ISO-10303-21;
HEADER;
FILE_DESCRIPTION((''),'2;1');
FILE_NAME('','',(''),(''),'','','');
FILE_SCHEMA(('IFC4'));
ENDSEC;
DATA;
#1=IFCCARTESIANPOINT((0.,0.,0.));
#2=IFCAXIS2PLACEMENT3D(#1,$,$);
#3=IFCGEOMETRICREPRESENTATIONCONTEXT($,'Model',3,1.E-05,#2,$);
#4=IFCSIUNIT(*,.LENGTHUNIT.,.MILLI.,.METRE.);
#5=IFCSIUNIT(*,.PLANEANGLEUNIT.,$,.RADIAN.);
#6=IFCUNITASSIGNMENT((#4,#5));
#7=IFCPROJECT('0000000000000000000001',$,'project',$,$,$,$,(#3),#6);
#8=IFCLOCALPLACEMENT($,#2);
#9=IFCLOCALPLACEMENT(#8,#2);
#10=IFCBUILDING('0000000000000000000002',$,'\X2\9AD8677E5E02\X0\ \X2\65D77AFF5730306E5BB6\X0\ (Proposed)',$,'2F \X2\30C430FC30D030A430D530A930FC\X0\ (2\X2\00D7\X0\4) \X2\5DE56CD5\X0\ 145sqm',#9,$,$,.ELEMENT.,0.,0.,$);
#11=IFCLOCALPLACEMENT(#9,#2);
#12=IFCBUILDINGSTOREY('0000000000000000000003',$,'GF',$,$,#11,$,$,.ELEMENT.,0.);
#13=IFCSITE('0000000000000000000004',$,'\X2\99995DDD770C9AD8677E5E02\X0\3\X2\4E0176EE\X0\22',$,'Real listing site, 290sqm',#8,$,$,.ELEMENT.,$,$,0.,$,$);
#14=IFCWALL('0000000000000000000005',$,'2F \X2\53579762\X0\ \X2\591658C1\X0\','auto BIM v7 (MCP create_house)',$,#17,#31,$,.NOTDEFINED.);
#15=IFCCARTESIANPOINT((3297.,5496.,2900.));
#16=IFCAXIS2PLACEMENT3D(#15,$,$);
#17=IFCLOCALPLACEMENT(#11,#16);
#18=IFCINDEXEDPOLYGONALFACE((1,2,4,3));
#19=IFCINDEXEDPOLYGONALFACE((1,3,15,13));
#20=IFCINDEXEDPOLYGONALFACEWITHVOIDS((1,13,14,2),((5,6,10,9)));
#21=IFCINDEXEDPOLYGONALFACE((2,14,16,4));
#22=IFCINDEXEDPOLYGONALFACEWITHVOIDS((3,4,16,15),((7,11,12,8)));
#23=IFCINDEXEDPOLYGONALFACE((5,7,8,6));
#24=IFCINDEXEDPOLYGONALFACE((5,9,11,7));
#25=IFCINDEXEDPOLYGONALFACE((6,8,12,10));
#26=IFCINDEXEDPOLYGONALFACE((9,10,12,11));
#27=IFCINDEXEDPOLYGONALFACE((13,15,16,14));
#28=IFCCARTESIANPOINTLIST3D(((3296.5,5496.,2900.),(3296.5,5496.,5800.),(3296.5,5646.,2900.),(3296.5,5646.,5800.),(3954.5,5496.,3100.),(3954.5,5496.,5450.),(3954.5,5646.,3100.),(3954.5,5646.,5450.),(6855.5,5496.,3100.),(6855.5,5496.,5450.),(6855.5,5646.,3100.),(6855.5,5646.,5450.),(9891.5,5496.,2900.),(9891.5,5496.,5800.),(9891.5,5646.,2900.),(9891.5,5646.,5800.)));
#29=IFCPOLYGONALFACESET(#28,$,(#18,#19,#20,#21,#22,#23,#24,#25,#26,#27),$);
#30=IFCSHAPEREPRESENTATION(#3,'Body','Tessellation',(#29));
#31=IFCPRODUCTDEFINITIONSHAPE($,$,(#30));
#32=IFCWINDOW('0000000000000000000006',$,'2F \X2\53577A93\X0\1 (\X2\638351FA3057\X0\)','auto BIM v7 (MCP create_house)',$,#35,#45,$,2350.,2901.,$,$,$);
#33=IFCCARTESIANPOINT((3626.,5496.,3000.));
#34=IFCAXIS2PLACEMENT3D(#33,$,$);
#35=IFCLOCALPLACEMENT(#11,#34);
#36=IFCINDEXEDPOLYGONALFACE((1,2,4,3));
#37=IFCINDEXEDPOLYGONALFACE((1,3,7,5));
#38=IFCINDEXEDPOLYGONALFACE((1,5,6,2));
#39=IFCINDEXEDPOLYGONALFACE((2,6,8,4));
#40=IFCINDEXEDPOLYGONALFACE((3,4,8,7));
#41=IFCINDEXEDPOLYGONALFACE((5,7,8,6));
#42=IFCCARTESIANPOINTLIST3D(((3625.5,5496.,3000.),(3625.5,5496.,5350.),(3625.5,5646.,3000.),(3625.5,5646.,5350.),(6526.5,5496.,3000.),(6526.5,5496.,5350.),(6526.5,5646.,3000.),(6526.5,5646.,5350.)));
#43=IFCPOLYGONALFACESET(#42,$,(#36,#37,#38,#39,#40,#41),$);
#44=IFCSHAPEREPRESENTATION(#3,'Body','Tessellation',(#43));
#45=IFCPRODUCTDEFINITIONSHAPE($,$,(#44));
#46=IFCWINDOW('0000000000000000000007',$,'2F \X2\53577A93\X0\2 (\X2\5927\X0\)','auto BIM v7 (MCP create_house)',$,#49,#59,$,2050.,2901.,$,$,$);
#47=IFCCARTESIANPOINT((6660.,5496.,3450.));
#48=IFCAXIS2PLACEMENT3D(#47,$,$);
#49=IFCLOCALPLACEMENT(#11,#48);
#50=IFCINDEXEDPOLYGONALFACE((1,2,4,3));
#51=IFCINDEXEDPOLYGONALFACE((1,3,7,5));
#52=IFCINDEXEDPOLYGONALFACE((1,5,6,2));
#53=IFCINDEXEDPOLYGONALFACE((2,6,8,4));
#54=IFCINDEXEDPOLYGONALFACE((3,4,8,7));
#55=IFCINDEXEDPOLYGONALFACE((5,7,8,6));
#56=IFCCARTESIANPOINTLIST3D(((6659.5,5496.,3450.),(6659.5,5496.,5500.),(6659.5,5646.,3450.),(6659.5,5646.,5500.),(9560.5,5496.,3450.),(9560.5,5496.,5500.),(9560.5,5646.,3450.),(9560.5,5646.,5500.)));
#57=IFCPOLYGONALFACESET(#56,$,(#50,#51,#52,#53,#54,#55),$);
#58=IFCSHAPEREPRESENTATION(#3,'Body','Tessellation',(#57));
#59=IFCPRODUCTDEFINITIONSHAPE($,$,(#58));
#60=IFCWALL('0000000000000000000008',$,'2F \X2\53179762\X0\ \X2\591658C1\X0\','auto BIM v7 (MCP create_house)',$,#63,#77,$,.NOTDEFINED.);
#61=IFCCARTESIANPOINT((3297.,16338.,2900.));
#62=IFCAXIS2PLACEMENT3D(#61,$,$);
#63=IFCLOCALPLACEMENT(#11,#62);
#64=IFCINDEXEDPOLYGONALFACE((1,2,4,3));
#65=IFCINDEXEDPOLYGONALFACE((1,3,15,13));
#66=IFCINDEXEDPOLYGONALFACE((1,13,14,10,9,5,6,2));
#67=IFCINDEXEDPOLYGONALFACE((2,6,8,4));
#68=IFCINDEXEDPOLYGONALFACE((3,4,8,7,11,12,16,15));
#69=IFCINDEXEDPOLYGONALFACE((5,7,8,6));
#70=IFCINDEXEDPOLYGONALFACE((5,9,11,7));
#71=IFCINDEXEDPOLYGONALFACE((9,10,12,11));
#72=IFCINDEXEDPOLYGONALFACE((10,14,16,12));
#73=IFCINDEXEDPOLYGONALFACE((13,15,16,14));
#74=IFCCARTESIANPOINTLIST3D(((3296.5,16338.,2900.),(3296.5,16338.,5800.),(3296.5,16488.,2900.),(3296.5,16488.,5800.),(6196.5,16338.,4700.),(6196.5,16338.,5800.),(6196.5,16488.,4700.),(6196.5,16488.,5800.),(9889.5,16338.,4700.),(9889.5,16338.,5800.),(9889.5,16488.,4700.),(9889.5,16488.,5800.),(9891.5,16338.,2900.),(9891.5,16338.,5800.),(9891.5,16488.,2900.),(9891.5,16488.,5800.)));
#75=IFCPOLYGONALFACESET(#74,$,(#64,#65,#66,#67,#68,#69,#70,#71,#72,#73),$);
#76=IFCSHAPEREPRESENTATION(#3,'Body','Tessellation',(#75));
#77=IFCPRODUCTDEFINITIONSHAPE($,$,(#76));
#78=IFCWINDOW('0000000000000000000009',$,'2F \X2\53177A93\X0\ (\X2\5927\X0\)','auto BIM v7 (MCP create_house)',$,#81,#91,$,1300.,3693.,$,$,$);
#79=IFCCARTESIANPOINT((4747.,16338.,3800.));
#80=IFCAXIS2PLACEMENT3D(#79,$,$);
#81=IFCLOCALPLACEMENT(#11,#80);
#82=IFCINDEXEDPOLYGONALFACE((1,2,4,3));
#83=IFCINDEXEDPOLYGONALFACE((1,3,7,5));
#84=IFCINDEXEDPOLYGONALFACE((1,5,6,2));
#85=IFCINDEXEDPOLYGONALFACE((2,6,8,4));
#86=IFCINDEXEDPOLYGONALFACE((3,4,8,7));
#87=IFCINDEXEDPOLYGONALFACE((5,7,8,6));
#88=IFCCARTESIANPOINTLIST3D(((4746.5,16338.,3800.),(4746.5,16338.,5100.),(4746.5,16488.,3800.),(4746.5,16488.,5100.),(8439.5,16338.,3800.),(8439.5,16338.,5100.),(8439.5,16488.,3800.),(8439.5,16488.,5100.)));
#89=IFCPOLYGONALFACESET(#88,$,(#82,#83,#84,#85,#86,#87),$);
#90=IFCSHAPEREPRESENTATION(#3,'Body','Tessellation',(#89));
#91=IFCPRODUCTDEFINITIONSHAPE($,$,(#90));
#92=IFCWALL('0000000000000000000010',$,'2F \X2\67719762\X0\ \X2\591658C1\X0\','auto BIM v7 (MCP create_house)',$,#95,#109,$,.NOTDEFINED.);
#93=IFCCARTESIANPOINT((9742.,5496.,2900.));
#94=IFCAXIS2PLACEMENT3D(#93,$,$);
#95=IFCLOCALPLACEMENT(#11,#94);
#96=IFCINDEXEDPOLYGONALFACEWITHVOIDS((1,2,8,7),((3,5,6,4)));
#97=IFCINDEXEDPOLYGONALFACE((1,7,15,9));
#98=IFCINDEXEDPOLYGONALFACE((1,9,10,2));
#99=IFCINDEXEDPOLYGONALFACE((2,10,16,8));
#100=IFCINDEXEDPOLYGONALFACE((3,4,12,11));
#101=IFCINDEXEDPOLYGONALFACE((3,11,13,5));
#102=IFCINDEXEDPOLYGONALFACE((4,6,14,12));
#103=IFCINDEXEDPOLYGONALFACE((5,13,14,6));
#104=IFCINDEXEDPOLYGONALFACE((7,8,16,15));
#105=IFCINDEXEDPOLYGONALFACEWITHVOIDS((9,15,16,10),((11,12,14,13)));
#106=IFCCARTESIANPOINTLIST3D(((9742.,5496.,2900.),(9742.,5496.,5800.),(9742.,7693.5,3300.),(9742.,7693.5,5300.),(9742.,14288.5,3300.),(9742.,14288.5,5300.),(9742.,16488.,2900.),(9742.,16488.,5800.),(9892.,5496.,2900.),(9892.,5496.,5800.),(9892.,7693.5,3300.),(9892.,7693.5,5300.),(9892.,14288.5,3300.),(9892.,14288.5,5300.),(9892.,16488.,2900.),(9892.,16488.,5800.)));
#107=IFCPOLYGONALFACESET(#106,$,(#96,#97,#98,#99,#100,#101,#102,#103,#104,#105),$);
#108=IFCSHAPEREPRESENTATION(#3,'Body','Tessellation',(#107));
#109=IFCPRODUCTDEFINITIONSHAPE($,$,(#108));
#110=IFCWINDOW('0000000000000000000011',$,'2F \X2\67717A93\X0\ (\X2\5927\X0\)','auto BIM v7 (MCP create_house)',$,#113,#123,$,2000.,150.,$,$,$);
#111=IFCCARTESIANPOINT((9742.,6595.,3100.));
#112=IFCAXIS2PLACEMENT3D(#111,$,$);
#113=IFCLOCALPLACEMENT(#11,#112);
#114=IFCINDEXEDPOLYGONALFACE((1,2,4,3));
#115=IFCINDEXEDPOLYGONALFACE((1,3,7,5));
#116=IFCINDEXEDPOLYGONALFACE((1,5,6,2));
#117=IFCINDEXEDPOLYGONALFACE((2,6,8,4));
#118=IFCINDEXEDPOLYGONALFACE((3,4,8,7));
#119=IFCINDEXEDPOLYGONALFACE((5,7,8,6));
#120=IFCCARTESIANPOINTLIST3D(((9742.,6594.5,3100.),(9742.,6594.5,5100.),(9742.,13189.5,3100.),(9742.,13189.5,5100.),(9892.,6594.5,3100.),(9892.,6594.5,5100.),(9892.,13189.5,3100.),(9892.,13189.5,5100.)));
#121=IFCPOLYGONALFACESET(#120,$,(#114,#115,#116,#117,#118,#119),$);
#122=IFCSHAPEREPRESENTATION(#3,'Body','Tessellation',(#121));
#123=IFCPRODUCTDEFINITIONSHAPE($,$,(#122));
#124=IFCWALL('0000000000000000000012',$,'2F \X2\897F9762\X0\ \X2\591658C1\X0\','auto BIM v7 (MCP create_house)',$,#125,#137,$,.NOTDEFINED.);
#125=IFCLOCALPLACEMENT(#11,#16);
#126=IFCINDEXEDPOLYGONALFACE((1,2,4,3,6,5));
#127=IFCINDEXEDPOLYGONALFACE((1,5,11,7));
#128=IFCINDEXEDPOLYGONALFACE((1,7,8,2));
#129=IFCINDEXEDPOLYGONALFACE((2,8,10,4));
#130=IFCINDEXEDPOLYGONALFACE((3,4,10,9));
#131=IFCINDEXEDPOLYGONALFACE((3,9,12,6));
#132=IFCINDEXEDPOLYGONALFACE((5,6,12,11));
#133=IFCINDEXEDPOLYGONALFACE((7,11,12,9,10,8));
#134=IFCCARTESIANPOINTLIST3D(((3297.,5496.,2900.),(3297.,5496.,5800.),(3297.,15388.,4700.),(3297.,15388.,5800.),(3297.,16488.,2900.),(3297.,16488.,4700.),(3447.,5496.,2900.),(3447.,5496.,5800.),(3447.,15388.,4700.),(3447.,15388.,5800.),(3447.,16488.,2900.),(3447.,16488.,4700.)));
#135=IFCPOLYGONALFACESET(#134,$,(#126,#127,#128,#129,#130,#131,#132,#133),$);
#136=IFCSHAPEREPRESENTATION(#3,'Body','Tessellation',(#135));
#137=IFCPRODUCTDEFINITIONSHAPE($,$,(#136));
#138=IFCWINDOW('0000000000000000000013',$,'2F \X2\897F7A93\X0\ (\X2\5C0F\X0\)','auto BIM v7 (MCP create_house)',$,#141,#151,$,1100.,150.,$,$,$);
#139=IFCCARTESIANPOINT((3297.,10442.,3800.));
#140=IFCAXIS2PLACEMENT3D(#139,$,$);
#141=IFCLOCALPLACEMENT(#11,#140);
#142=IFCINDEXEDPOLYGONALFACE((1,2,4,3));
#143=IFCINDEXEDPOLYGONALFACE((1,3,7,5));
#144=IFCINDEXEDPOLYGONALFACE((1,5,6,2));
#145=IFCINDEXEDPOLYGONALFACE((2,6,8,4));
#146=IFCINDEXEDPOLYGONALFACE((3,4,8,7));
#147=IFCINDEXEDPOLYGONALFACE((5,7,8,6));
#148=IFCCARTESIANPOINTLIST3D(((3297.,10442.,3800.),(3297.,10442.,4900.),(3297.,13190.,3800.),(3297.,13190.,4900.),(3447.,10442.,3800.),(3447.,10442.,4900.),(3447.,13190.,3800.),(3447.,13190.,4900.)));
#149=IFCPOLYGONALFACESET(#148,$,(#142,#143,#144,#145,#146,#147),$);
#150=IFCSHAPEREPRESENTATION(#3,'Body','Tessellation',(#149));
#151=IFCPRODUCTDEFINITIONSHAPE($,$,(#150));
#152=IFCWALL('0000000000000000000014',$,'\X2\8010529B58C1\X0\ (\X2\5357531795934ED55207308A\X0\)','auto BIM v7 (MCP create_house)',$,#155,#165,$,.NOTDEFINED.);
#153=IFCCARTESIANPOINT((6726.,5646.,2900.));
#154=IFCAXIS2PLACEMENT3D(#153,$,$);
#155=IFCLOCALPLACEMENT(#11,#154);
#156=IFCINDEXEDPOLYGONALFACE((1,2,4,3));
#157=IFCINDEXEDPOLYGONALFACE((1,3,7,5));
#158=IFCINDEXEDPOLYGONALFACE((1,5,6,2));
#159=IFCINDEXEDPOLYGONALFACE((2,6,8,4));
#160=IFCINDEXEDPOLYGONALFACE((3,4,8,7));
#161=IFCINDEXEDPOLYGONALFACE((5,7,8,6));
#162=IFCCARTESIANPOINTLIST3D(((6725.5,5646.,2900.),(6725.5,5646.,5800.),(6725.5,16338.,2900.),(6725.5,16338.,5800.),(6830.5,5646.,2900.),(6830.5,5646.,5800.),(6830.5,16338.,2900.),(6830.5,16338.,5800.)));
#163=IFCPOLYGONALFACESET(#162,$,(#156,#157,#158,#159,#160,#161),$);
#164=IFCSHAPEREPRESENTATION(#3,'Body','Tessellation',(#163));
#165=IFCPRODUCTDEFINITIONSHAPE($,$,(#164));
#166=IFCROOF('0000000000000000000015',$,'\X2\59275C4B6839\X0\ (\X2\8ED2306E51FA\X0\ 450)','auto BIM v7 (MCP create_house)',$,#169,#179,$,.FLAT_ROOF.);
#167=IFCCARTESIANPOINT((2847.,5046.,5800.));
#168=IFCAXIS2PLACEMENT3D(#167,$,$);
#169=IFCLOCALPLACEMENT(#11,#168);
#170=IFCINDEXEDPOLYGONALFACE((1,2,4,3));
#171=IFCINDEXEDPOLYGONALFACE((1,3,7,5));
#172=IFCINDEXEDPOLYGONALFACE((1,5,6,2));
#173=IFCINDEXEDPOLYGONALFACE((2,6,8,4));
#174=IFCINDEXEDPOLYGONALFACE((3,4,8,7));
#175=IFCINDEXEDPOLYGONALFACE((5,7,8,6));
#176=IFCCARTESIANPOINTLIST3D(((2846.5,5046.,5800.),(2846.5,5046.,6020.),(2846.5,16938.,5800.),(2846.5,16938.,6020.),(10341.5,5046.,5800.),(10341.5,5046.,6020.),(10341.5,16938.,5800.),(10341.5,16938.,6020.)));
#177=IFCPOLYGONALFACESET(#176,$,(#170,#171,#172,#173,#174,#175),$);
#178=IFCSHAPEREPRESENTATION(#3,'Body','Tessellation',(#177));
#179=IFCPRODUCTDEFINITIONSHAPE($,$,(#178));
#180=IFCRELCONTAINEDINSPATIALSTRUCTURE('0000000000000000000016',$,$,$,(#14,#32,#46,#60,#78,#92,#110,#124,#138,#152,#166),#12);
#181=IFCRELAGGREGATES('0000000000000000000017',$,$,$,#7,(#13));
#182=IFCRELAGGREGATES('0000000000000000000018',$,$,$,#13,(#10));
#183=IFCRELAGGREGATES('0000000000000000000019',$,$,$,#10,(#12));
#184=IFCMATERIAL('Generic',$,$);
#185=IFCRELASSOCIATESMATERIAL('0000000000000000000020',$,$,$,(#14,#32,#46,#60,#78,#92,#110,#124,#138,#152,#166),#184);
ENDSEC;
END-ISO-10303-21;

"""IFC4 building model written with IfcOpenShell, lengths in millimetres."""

from ifc_helpers import new_model, si_unit, frame, frame_2d, origin, place, context, project, spatial, rectangle, extrude, material, element, fill, save


model = new_model("IFC4")

# Units and contexts
model_context = context("Model", 3, precision=1e-05, world=origin())
ifc_project = project(units=[si_unit("LENGTHUNIT", "METRE", prefix="MILLI"), si_unit("PLANEANGLEUNIT", "RADIAN")], contexts=[model_context])

# Site, building, storey
site_placement = place(None, origin())
site = spatial("IfcSite", under=ifc_project, at=site_placement, Name="香川県高松市3丁目22", ObjectType="Real listing site, 290sqm", CompositionType="ELEMENT", RefElevation=0.0)
building_placement = place(site_placement, origin())
building = spatial("IfcBuilding", under=site, at=building_placement, Name="高松市 旗竿地の家 (Proposed)", ObjectType="2F ツーバイフォー (2×4) 工法 145sqm", CompositionType="ELEMENT", ElevationOfRefHeight=0.0, ElevationOfTerrain=0.0)
storey_placement = place(building_placement, origin())
storey = spatial("IfcBuildingStorey", under=building, at=storey_placement, Name="GF", CompositionType="ELEMENT", Elevation=0.0)

# Shared definitions
ifc_material = material(Name="Generic")

# Wall, openings, windows
wall_1_placement = place(storey_placement, frame((3297.0, 5496.0, 2900.0)))
wall_1 = element("IfcWall", 1, at=wall_1_placement, inside=storey, material=ifc_material, Name="2F 南面 外壁", Description="auto BIM v7 (MCP create_house)", PredefinedType="NOTDEFINED", context=model_context, shape_type="SweptSolid", body=[
    extrude(rectangle(XDim=6595.0, YDim=150.0, at=frame_2d((3297.0, 75.0))), frame((3297.0, 5496.0, 2900.0)), (0.0, 0.0, 1.0), 2900.0),
])
opening_1_placement = place(storey_placement, frame((3626.0, 5496.0, 3000.0)))
opening_1 = element("IfcOpeningElement", 2, at=opening_1_placement, cuts=wall_1, PredefinedType="NOTDEFINED", context=model_context, shape_type="SweptSolid", body=[
    extrude(rectangle(XDim=2901.0, YDim=150.0, at=frame_2d((1450.0, 75.0))), frame((3626.0, 5496.0, 3000.0)), (0.0, 0.0, 1.0), 2350.0),
])
opening_2_placement = place(storey_placement, frame((6660.0, 5496.0, 3450.0)))
opening_2 = element("IfcOpeningElement", 3, at=opening_2_placement, cuts=wall_1, PredefinedType="NOTDEFINED", context=model_context, shape_type="SweptSolid", body=[
    extrude(rectangle(XDim=2901.0, YDim=150.0, at=frame_2d((1450.0, 75.0))), frame((6660.0, 5496.0, 3450.0)), (0.0, 0.0, 1.0), 2050.0),
])
window_1_placement = place(storey_placement, frame((3626.0, 5496.0, 3000.0)))
window_1 = element("IfcWindow", 4, at=window_1_placement, inside=storey, material=ifc_material, Name="2F 南窓1 (掃出し)", Description="auto BIM v7 (MCP create_house)", OverallHeight=2350.0, OverallWidth=2901.0, context=model_context, shape_type="SweptSolid", body=[
    extrude(rectangle(XDim=2901.0, YDim=150.0, at=frame_2d((1450.0, 75.0))), frame((3626.0, 5496.0, 3000.0)), (0.0, 0.0, 1.0), 2350.0),
])
fill(opening_1, window_1)
window_2_placement = place(storey_placement, frame((6660.0, 5496.0, 3450.0)))
window_2 = element("IfcWindow", 5, at=window_2_placement, inside=storey, material=ifc_material, Name="2F 南窓2 (大)", Description="auto BIM v7 (MCP create_house)", OverallHeight=2050.0, OverallWidth=2901.0, context=model_context, shape_type="SweptSolid", body=[
    extrude(rectangle(XDim=2901.0, YDim=150.0, at=frame_2d((1450.0, 75.0))), frame((6660.0, 5496.0, 3450.0)), (0.0, 0.0, 1.0), 2050.0),
])
fill(opening_2, window_2)

# Walls, openings, windows
wall_2_placement = place(storey_placement, frame((3297.0, 16338.0, 2900.0)))
wall_2 = element("IfcWall", 6, at=wall_2_placement, inside=storey, material=ifc_material, Name="2F 北面 外壁", Description="auto BIM v7 (MCP create_house)", PredefinedType="NOTDEFINED", context=model_context, shape_type="SweptSolid", body=[
    extrude(rectangle(XDim=6595.0, YDim=150.0, at=frame_2d((3297.0, 75.0))), frame((3297.0, 16338.0, 2900.0)), (0.0, 0.0, 1.0), 2900.0),
])
opening_3_placement = place(storey_placement, frame((4747.0, 16338.0, 3800.0)))
opening_3 = element("IfcOpeningElement", 7, at=opening_3_placement, cuts=wall_2, PredefinedType="NOTDEFINED", context=model_context, shape_type="SweptSolid", body=[
    extrude(rectangle(XDim=3693.0, YDim=150.0, at=frame_2d((1846.0, 75.0))), frame((4747.0, 16338.0, 3800.0)), (0.0, 0.0, 1.0), 1300.0),
])
window_3_placement = place(storey_placement, frame((4747.0, 16338.0, 3800.0)))
window_3 = element("IfcWindow", 8, at=window_3_placement, inside=storey, material=ifc_material, Name="2F 北窓 (大)", Description="auto BIM v7 (MCP create_house)", OverallHeight=1300.0, OverallWidth=3693.0, context=model_context, shape_type="SweptSolid", body=[
    extrude(rectangle(XDim=3693.0, YDim=150.0, at=frame_2d((1846.0, 75.0))), frame((4747.0, 16338.0, 3800.0)), (0.0, 0.0, 1.0), 1300.0),
])
fill(opening_3, window_3)
wall_3_placement = place(storey_placement, frame((9742.0, 5496.0, 2900.0)))
wall_3 = element("IfcWall", 9, at=wall_3_placement, inside=storey, material=ifc_material, Name="2F 東面 外壁", Description="auto BIM v7 (MCP create_house)", PredefinedType="NOTDEFINED", context=model_context, shape_type="SweptSolid", body=[
    extrude(rectangle(XDim=150.0, YDim=10992.0, at=frame_2d((75.0, 5496.0))), frame((9742.0, 5496.0, 2900.0)), (0.0, 0.0, 1.0), 2900.0),
])
opening_4_placement = place(storey_placement, frame((9742.0, 6595.0, 3100.0)))
opening_4 = element("IfcOpeningElement", 10, at=opening_4_placement, cuts=wall_3, PredefinedType="NOTDEFINED", context=model_context, shape_type="SweptSolid", body=[
    extrude(rectangle(XDim=150.0, YDim=6595.0, at=frame_2d((75.0, 3297.0))), frame((9742.0, 6595.0, 3100.0)), (0.0, 0.0, 1.0), 2000.0),
])
window_4_placement = place(storey_placement, frame((9742.0, 6595.0, 3100.0)))
window_4 = element("IfcWindow", 11, at=window_4_placement, inside=storey, material=ifc_material, Name="2F 東窓 (大)", Description="auto BIM v7 (MCP create_house)", OverallHeight=2000.0, OverallWidth=150.0, context=model_context, shape_type="SweptSolid", body=[
    extrude(rectangle(XDim=150.0, YDim=6595.0, at=frame_2d((75.0, 3297.0))), frame((9742.0, 6595.0, 3100.0)), (0.0, 0.0, 1.0), 2000.0),
])
fill(opening_4, window_4)
wall_4_placement = place(storey_placement, frame((3297.0, 5496.0, 2900.0)))
wall_4 = element("IfcWall", 12, at=wall_4_placement, inside=storey, material=ifc_material, Name="2F 西面 外壁", Description="auto BIM v7 (MCP create_house)", PredefinedType="NOTDEFINED", context=model_context, shape_type="SweptSolid", body=[
    extrude(rectangle(XDim=150.0, YDim=10992.0, at=frame_2d((75.0, 5496.0))), frame((3297.0, 5496.0, 2900.0)), (0.0, 0.0, 1.0), 2900.0),
])
opening_5_placement = place(storey_placement, frame((3297.0, 10442.0, 3800.0)))
opening_5 = element("IfcOpeningElement", 13, at=opening_5_placement, cuts=wall_4, PredefinedType="NOTDEFINED", context=model_context, shape_type="SweptSolid", body=[
    extrude(rectangle(XDim=150.0, YDim=2748.0, at=frame_2d((75.0, 1374.0))), frame((3297.0, 10442.0, 3800.0)), (0.0, 0.0, 1.0), 1100.0),
])
window_5_placement = place(storey_placement, frame((3297.0, 10442.0, 3800.0)))
window_5 = element("IfcWindow", 14, at=window_5_placement, inside=storey, material=ifc_material, Name="2F 西窓 (小)", Description="auto BIM v7 (MCP create_house)", OverallHeight=1100.0, OverallWidth=150.0, context=model_context, shape_type="SweptSolid", body=[
    extrude(rectangle(XDim=150.0, YDim=2748.0, at=frame_2d((75.0, 1374.0))), frame((3297.0, 10442.0, 3800.0)), (0.0, 0.0, 1.0), 1100.0),
])
fill(opening_5, window_5)

# Wall
wall_5_placement = place(storey_placement, frame((6726.0, 5646.0, 2900.0)))
element("IfcWall", 15, at=wall_5_placement, inside=storey, material=ifc_material, Name="耐力壁 (南北間仕切り)", Description="auto BIM v7 (MCP create_house)", PredefinedType="NOTDEFINED", context=model_context, shape_type="SweptSolid", body=[
    extrude(rectangle(XDim=105.0, YDim=10692.0, at=frame_2d((52.0, 5346.0))), frame((6726.0, 5646.0, 2900.0)), (0.0, 0.0, 1.0), 2900.0),
])

# Roof
roof_placement = place(storey_placement, frame((2847.0, 5046.0, 5800.0)))
element("IfcRoof", 16, at=roof_placement, inside=storey, material=ifc_material, Name="大屋根 (軒の出 450)", Description="auto BIM v7 (MCP create_house)", PredefinedType="FLAT_ROOF", context=model_context, shape_type="SweptSolid", body=[
    extrude(rectangle(XDim=7495.0, YDim=11892.0, at=frame_2d((3747.0, 5946.0))), frame((2847.0, 5046.0, 5800.0)), (0.0, 0.0, 1.0), 220.0),
])

save(model, "model.ifc")
